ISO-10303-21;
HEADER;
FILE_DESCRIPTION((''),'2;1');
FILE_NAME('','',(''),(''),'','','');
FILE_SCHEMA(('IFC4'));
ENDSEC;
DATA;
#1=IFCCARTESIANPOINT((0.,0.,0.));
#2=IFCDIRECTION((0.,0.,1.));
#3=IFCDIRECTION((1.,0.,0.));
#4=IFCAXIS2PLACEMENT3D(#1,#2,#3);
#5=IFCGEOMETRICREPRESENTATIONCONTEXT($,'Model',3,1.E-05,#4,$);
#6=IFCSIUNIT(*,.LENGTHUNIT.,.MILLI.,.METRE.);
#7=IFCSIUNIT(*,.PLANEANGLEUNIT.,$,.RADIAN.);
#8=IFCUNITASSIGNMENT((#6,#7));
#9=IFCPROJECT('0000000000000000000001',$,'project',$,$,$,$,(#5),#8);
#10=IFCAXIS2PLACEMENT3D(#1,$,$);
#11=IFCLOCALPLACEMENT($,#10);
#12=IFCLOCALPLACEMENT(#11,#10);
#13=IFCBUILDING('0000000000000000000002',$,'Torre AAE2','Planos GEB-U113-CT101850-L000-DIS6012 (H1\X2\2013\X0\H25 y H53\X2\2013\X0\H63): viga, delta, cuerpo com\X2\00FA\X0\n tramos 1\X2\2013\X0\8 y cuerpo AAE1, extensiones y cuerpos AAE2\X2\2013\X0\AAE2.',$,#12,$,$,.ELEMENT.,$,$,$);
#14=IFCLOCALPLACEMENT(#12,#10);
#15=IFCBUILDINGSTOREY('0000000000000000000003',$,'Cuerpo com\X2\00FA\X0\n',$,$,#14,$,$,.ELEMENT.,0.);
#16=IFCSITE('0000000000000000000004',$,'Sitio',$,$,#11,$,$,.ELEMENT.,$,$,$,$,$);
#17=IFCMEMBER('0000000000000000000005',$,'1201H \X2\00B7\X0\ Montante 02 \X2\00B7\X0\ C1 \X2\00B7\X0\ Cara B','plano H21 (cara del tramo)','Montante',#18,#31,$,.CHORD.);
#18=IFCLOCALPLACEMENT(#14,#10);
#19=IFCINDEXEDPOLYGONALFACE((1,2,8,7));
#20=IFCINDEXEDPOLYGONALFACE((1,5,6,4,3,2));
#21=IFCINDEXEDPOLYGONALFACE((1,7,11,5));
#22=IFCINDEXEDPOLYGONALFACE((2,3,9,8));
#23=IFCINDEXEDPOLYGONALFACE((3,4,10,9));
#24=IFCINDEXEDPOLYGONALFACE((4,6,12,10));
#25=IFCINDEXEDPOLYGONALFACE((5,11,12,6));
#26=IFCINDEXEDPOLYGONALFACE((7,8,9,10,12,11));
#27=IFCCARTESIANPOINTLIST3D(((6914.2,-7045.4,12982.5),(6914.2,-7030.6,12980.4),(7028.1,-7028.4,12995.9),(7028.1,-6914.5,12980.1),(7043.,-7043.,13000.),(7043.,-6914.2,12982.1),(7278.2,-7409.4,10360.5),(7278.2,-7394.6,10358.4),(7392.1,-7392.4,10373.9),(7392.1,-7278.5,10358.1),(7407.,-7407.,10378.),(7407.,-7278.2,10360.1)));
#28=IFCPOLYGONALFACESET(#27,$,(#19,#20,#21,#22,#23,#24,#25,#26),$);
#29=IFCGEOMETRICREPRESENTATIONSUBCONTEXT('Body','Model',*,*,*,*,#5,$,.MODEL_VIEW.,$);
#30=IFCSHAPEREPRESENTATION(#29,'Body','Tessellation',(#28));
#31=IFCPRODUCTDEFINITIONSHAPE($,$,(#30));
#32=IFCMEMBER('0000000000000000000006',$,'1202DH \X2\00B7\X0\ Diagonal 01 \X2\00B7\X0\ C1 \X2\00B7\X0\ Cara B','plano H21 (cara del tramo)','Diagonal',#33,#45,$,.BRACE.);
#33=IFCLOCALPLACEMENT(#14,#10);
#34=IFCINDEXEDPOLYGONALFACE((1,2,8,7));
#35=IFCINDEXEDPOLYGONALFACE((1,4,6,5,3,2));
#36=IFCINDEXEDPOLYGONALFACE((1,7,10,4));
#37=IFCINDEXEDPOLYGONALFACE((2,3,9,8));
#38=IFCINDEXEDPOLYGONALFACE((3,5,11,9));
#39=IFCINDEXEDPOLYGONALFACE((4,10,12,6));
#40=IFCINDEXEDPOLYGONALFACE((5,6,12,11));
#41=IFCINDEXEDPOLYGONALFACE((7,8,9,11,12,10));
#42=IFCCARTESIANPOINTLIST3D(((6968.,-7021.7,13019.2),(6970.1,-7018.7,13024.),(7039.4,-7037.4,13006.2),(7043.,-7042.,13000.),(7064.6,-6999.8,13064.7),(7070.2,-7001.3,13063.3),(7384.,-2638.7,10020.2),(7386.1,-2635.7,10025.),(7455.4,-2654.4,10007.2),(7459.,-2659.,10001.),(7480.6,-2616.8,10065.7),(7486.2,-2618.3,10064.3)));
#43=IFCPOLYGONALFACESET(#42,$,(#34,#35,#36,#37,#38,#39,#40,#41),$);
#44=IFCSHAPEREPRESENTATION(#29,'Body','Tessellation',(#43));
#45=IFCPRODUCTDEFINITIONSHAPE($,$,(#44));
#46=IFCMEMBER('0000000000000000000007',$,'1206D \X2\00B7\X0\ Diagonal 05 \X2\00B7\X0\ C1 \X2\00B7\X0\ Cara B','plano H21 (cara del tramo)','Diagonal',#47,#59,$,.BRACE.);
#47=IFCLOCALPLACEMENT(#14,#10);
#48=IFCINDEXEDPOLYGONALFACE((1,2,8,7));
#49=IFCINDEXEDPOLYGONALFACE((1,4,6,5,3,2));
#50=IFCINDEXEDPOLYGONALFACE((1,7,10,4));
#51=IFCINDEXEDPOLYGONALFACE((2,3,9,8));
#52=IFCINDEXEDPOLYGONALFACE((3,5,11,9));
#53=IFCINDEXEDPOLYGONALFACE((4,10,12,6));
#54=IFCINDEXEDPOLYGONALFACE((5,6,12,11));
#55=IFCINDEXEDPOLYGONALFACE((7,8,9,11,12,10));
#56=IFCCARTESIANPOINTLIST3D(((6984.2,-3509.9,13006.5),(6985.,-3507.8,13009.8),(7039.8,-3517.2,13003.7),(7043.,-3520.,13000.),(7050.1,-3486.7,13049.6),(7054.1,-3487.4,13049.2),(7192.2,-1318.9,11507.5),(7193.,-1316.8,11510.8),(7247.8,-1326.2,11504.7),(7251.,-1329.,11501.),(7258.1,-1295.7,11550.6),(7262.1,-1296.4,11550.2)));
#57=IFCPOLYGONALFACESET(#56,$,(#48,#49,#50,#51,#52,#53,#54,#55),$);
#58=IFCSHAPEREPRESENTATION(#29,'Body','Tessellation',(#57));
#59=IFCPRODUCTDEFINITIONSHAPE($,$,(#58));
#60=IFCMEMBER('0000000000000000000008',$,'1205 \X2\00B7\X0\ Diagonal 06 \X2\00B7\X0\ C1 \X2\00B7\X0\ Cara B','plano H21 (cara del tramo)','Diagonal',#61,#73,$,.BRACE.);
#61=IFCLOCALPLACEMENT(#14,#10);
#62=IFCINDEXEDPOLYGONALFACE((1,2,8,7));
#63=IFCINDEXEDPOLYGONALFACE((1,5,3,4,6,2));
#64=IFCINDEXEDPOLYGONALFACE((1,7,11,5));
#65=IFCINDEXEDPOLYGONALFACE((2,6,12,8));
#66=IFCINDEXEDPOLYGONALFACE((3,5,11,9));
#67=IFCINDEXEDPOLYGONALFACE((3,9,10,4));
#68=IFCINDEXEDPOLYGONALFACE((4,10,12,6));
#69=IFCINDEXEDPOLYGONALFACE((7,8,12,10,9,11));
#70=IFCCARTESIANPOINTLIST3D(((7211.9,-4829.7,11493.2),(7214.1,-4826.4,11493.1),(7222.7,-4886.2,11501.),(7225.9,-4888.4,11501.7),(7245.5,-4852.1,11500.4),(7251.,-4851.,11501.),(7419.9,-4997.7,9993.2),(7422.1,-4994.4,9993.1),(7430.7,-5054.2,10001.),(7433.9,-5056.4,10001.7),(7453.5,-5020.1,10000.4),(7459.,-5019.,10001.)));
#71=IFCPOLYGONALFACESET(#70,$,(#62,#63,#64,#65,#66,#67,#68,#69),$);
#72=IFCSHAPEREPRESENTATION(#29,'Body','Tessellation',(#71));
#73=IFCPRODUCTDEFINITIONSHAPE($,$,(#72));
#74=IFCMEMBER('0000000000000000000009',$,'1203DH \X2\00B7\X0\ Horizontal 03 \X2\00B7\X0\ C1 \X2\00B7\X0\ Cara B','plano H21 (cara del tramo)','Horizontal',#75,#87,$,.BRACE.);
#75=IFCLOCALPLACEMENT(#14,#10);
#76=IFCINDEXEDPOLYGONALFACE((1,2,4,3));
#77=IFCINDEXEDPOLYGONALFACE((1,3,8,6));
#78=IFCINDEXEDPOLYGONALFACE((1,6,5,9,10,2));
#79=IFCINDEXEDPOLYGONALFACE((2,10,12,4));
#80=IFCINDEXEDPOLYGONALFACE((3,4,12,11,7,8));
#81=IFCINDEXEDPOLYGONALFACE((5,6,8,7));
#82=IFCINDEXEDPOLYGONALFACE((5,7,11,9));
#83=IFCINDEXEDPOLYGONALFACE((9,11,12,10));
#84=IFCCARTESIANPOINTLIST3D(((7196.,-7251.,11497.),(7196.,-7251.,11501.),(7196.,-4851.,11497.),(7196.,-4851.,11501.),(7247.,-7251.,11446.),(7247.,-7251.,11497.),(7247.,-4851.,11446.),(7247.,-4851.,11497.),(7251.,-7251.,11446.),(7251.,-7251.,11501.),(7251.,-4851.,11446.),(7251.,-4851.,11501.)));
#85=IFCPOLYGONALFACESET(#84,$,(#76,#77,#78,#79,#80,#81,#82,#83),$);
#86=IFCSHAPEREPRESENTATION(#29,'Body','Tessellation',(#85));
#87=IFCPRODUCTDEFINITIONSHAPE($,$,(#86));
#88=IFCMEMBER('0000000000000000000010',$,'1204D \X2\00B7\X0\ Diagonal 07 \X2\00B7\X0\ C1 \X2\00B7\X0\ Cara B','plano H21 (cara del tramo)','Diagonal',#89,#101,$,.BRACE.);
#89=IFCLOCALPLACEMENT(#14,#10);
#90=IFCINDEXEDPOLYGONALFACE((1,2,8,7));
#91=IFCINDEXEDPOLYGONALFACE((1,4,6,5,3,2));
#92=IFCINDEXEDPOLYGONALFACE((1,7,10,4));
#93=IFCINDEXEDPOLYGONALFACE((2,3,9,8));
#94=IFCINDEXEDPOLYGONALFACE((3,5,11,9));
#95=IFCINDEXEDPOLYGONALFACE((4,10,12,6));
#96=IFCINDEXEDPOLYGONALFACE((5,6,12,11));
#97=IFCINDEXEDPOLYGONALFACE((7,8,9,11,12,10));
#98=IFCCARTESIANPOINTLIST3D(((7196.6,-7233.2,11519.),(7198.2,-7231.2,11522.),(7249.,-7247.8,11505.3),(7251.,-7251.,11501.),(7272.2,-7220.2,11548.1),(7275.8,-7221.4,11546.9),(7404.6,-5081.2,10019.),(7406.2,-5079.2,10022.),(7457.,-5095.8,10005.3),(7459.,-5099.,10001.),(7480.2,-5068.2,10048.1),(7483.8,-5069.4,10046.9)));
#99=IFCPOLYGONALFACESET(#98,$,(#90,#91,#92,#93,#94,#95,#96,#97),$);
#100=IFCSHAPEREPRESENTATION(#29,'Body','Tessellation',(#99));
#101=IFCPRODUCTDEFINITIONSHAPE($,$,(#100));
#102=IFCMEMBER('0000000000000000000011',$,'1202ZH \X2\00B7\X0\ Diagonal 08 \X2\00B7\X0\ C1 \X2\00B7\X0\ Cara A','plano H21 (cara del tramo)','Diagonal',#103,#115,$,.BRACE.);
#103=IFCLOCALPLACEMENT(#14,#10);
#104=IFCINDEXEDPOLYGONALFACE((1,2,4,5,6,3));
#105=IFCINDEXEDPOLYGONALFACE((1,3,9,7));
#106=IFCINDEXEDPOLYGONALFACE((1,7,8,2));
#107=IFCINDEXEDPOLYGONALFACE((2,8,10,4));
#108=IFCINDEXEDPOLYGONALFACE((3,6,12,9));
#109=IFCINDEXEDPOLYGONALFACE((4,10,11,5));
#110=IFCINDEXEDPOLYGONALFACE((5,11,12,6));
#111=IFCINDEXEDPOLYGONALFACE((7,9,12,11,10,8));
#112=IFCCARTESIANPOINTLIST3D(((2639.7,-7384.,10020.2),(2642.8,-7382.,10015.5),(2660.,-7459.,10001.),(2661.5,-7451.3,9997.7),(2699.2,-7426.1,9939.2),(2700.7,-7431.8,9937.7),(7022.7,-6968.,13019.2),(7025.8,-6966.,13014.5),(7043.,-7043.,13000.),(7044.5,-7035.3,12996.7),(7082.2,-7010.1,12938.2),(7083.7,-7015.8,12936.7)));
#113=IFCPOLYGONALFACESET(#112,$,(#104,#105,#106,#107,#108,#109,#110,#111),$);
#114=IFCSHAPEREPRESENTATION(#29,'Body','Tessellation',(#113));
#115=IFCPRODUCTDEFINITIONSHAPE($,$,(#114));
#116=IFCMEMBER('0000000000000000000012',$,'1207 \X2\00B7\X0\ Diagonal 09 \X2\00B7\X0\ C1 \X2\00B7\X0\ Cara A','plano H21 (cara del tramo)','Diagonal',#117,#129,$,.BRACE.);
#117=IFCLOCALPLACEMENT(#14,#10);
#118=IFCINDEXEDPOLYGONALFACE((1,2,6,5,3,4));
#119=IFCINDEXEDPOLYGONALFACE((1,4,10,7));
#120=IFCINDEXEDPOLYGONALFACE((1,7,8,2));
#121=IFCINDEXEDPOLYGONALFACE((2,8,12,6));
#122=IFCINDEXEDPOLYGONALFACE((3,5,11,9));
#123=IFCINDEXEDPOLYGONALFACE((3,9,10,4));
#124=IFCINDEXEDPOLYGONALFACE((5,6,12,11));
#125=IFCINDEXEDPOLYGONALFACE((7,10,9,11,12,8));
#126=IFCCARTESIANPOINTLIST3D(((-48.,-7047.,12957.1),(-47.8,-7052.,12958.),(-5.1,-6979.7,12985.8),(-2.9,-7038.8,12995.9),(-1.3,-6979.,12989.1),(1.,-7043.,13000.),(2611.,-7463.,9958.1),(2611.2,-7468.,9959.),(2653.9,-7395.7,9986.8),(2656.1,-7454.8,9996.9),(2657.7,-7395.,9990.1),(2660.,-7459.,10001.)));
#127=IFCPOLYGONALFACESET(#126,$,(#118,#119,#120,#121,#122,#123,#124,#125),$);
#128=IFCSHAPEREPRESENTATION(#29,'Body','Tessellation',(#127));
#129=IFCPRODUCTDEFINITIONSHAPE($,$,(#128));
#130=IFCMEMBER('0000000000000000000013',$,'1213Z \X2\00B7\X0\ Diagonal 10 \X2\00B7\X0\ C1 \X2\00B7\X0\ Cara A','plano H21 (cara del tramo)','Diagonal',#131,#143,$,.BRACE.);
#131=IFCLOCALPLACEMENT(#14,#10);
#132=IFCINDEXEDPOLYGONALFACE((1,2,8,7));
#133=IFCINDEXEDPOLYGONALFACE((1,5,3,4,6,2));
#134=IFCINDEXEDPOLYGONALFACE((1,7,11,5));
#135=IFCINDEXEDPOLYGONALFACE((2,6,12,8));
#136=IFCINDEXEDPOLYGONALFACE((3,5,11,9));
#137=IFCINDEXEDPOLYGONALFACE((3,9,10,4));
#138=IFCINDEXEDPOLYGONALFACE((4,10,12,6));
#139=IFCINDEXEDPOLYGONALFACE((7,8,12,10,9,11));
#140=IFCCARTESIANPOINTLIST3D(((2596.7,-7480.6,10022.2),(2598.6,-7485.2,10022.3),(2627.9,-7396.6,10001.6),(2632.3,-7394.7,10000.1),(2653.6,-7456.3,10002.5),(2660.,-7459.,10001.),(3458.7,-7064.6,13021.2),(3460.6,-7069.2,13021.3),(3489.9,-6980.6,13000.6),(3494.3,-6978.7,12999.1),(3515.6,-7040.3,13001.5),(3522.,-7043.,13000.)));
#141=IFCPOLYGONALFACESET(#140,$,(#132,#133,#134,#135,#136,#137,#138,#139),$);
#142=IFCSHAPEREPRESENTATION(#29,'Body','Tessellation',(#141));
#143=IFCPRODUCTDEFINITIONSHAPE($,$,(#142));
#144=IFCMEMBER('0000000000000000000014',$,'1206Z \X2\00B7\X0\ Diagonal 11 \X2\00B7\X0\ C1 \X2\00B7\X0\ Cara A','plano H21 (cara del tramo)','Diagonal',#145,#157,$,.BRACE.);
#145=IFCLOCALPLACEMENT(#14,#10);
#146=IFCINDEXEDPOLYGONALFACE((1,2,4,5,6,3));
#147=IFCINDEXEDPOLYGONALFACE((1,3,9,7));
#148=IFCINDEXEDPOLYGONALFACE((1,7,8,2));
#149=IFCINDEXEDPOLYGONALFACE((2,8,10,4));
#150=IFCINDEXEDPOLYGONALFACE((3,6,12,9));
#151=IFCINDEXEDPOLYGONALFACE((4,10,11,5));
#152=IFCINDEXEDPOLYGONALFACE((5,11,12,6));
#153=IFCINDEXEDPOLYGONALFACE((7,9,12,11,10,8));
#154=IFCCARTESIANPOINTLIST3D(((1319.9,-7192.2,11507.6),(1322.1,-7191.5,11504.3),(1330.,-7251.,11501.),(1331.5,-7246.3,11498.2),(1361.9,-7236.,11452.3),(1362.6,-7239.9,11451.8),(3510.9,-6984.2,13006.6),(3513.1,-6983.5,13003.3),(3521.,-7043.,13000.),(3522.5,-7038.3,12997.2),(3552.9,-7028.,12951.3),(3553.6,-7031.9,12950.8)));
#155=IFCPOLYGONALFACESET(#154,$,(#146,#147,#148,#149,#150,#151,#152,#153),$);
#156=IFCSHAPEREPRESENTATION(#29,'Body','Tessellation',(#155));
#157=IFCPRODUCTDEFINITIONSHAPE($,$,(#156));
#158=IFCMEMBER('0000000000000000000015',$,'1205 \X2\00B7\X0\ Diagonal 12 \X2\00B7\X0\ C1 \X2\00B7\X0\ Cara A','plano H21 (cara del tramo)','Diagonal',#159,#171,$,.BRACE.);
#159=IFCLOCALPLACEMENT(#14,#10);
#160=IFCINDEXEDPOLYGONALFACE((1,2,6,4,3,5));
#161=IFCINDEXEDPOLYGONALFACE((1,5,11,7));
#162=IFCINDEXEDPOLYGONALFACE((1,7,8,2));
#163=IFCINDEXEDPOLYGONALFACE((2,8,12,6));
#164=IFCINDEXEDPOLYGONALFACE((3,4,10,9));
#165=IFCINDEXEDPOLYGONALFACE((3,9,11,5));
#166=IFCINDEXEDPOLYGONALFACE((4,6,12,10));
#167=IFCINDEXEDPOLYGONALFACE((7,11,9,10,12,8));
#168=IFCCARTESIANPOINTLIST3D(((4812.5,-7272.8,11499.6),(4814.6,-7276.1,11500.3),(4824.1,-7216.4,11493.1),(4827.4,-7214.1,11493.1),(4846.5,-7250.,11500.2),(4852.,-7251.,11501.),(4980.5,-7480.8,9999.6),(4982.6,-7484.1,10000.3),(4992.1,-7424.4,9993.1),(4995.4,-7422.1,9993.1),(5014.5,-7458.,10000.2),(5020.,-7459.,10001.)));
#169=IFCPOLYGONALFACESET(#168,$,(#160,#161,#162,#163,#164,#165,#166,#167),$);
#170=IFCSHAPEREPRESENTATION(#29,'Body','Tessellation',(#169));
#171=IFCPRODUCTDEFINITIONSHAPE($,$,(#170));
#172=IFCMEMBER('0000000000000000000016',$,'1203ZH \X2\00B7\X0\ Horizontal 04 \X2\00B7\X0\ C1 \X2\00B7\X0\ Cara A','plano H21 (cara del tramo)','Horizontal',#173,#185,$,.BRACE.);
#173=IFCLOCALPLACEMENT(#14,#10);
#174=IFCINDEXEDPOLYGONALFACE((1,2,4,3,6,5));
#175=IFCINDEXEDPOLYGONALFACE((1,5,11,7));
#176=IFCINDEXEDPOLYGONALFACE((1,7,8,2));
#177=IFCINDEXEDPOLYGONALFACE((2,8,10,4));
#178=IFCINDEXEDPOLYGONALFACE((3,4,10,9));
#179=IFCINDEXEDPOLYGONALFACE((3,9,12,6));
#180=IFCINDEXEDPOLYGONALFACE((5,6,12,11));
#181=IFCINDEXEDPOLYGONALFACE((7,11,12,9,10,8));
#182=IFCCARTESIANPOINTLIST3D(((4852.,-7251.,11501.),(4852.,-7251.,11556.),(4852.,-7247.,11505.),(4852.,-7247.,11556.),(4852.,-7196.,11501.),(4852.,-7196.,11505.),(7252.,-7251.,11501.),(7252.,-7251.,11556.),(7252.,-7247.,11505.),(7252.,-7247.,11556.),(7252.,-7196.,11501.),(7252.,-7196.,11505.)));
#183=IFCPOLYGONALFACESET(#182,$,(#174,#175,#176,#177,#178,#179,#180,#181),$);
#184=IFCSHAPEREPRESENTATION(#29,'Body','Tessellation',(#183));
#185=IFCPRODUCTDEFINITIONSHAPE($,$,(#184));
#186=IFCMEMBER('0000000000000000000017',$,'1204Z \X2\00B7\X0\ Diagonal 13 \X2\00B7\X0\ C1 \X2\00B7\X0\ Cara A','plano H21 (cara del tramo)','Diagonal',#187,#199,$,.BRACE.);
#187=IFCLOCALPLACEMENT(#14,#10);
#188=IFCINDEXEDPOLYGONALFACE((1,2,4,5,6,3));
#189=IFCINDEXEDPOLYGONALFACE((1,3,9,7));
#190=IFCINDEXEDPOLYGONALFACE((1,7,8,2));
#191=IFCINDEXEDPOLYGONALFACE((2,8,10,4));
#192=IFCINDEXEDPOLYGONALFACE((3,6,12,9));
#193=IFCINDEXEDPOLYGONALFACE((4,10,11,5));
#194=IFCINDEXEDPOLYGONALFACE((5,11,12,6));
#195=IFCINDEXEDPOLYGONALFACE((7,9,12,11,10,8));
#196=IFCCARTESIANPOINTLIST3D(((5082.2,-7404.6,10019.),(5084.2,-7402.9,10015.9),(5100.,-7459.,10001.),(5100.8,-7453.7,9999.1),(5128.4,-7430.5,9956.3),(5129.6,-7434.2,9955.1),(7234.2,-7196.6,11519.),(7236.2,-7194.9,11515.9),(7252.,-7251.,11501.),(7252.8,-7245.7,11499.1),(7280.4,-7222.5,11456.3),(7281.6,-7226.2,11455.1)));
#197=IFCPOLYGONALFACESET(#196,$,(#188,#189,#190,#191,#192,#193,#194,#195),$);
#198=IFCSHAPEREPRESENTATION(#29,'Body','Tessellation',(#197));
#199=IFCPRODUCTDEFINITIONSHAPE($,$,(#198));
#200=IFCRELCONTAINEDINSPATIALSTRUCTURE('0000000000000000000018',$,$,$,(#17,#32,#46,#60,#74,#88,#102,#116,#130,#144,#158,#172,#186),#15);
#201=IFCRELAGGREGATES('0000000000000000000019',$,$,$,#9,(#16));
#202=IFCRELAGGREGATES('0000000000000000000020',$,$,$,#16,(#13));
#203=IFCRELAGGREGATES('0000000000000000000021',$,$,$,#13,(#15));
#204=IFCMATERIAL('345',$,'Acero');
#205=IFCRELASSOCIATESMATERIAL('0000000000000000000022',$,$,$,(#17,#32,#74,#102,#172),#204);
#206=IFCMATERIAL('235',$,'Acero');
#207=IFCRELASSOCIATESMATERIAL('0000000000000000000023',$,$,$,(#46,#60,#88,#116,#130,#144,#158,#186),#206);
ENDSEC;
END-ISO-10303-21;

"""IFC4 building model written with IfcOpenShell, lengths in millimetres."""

from ifc_helpers import new_model, si_unit, frame, frame_2d, origin, origin_with_axes, place, context, subcontext, project, spatial, l_section, extrude, material, element, save


model = new_model("IFC4")

# Units and contexts
model_context = context("Model", 3, precision=1e-05, world=origin_with_axes())
body_context = subcontext(model_context, "Body", "Model", "MODEL_VIEW")
ifc_project = project(units=[si_unit("LENGTHUNIT", "METRE", prefix="MILLI"), si_unit("PLANEANGLEUNIT", "RADIAN")], contexts=[model_context])

# Site, building, storey
site_placement = place(None, origin())
site = spatial("IfcSite", under=ifc_project, at=site_placement, Name="Sitio", CompositionType="ELEMENT")
building_placement = place(site_placement, origin())
building = spatial("IfcBuilding", under=site, at=building_placement, Name="Torre AAE2", Description="Planos GEB-U113-CT101850-L000-DIS6012 (H1–H25 y H53–H63): viga, delta, cuerpo común tramos 1–8 y cuerpo AAE1, extensiones y cuerpos AAE2–AAE2.", CompositionType="ELEMENT")
storey_placement = place(building_placement, origin())
storey = spatial("IfcBuildingStorey", under=building, at=storey_placement, Name="Cuerpo común", CompositionType="ELEMENT", Elevation=0.0)

# Members
ifc_material_1 = material(Name="345", Category="Acero")
ifc_material_2 = material(Name="235", Category="Acero")
member_1_placement = place(storey_placement, frame((7043.0, -7043.0, 13000.0), z_axis=(0.136225, -0.136225, -0.981267), x_axis=(-0.990678, -0.018732, -0.134931)))
element("IfcMember", 1, at=member_1_placement, inside=storey, material=ifc_material_1, Name="1201H · Montante 02 · C1 · Cara B", Description="plano H21 (cara del tramo)", ObjectType="Montante", PredefinedType="CHORD", context=body_context, shape_type="SweptSolid", body=[
    extrude(l_section(Depth=130.0, Width=130.0, Thickness=15.0, at=frame_2d((65.0, 65.0))), None, (0.0, 0.0, 1.0), 2672.1),
])
member_2_placement = place(storey_placement, frame((7043.0, -7042.0, 13000.0), z_axis=(0.078092, 0.822778, -0.562973), x_axis=(-0.937055, 0.253354, 0.240292)))
element("IfcMember", 2, at=member_2_placement, inside=storey, material=ifc_material_1, Name="1202DH · Diagonal 01 · C1 · Cara B", Description="plano H21 (cara del tramo)", ObjectType="Diagonal", PredefinedType="BRACE", context=body_context, shape_type="SweptSolid", body=[
    extrude(l_section(Depth=80.0, Width=80.0, Thickness=6.0, at=frame_2d((40.0, 40.0))), None, (0.0, 0.0, 1.0), 5327.1),
])
member_3_placement = place(storey_placement, frame((7043.0, -3520.0, 13000.0), z_axis=(0.078112, 0.822804, -0.562932), x_axis=(-0.979778, 0.167693, 0.109153)))
element("IfcMember", 3, at=member_3_placement, inside=storey, material=ifc_material_2, Name="1206D · Diagonal 05 · C1 · Cara B", Description="plano H21 (cara del tramo)", ObjectType="Diagonal", PredefinedType="BRACE", context=body_context, shape_type="SweptSolid", body=[
    extrude(l_section(Depth=60.0, Width=60.0, Thickness=4.0, at=frame_2d((30.0, 30.0))), None, (0.0, 0.0, 1.0), 2662.8),
])
member_4_placement = place(storey_placement, frame((7459.0, -5019.0, 10001.0), z_axis=(-0.136515, 0.110262, 0.984483), x_axis=(-0.819145, 0.54631, -0.174775)))
element("IfcMember", 4, at=member_4_placement, inside=storey, material=ifc_material_2, Name="1205 · Diagonal 06 · C1 · Cara B", Description="plano H21 (cara del tramo)", ObjectType="Diagonal", PredefinedType="BRACE", context=body_context, shape_type="SweptSolid", body=[
    extrude(l_section(Depth=45.0, Width=45.0, Thickness=4.0, at=frame_2d((22.5, 22.5))), None, (0.0, 0.0, 1.0), 1523.6),
])
member_5_placement = place(storey_placement, frame((7251.0, -4851.0, 11501.0), z_axis=(0.0, -1.0, 0.0), x_axis=(-1.0, 0.0, 0.0)))
element("IfcMember", 5, at=member_5_placement, inside=storey, material=ifc_material_1, Name="1203DH · Horizontal 03 · C1 · Cara B", Description="plano H21 (cara del tramo)", ObjectType="Horizontal", PredefinedType="BRACE", context=body_context, shape_type="SweptSolid", body=[
    extrude(l_section(Depth=55.0, Width=55.0, Thickness=4.0, at=frame_2d((27.5, 27.5))), None, (0.0, 0.0, 1.0), 2400.0),
])
member_6_placement = place(storey_placement, frame((7251.0, -7251.0, 11501.0), z_axis=(0.079045, 0.81781, -0.570035), x_axis=(-0.906797, 0.296517, 0.29966)))
element("IfcMember", 6, at=member_6_placement, inside=storey, material=ifc_material_2, Name="1204D · Diagonal 07 · C1 · Cara B", Description="plano H21 (cara del tramo)", ObjectType="Diagonal", PredefinedType="BRACE", context=body_context, shape_type="SweptSolid", body=[
    extrude(l_section(Depth=60.0, Width=60.0, Thickness=4.0, at=frame_2d((30.0, 30.0))), None, (0.0, 0.0, 1.0), 2631.4),
])
member_7_placement = place(storey_placement, frame((7043.0, -7043.0, 13000.0), z_axis=(-0.822778, -0.078092, -0.562973), x_axis=(-0.253386, 0.937033, 0.240342)))
element("IfcMember", 7, at=member_7_placement, inside=storey, material=ifc_material_1, Name="1202ZH · Diagonal 08 · C1 · Cara A", Description="plano H21 (cara del tramo)", ObjectType="Diagonal", PredefinedType="BRACE", context=body_context, shape_type="SweptSolid", body=[
    extrude(l_section(Depth=80.0, Width=80.0, Thickness=6.0, at=frame_2d((40.0, 40.0))), None, (0.0, 0.0, 1.0), 5327.1),
])
member_8_placement = place(storey_placement, frame((2660.0, -7459.0, 10001.0), z_axis=(-0.659874, 0.103237, 0.74425), x_axis=(-0.035769, 0.985077, -0.168357)))
element("IfcMember", 8, at=member_8_placement, inside=storey, material=ifc_material_2, Name="1207 · Diagonal 09 · C1 · Cara A", Description="plano H21 (cara del tramo)", ObjectType="Diagonal", PredefinedType="BRACE", context=body_context, shape_type="SweptSolid", body=[
    extrude(l_section(Depth=65.0, Width=65.0, Thickness=5.0, at=frame_2d((32.5, 32.5))), None, (0.0, 0.0, 1.0), 4029.6),
])
member_9_placement = place(storey_placement, frame((2660.0, -7459.0, 10001.0), z_axis=(0.273822, 0.132146, 0.952659), x_axis=(-0.396066, 0.918122, -0.013514)))
element("IfcMember", 9, at=member_9_placement, inside=storey, material=ifc_material_2, Name="1213Z · Diagonal 10 · C1 · Cara A", Description="plano H21 (cara del tramo)", ObjectType="Diagonal", PredefinedType="BRACE", context=body_context, shape_type="SweptSolid", body=[
    extrude(l_section(Depth=70.0, Width=70.0, Thickness=5.0, at=frame_2d((35.0, 35.0))), None, (0.0, 0.0, 1.0), 3148.0),
])
member_10_placement = place(storey_placement, frame((3521.0, -7043.0, 13000.0), z_axis=(-0.822804, -0.078112, -0.562932), x_axis=(-0.167732, 0.979764, 0.109213)))
element("IfcMember", 10, at=member_10_placement, inside=storey, material=ifc_material_2, Name="1206Z · Diagonal 11 · C1 · Cara A", Description="plano H21 (cara del tramo)", ObjectType="Diagonal", PredefinedType="BRACE", context=body_context, shape_type="SweptSolid", body=[
    extrude(l_section(Depth=60.0, Width=60.0, Thickness=4.0, at=frame_2d((30.0, 30.0))), None, (0.0, 0.0, 1.0), 2662.8),
])
member_11_placement = place(storey_placement, frame((5020.0, -7459.0, 10001.0), z_axis=(-0.110262, 0.136515, 0.984483), x_axis=(-0.546389, 0.819092, -0.174776)))
element("IfcMember", 11, at=member_11_placement, inside=storey, material=ifc_material_2, Name="1205 · Diagonal 12 · C1 · Cara A", Description="plano H21 (cara del tramo)", ObjectType="Diagonal", PredefinedType="BRACE", context=body_context, shape_type="SweptSolid", body=[
    extrude(l_section(Depth=45.0, Width=45.0, Thickness=4.0, at=frame_2d((22.5, 22.5))), None, (0.0, 0.0, 1.0), 1523.6),
])
member_12_placement = place(storey_placement, frame((4852.0, -7251.0, 11501.0), z_axis=(1.0, 0.0, 0.0), x_axis=(0.0, 1.0, 0.0)))
element("IfcMember", 12, at=member_12_placement, inside=storey, material=ifc_material_1, Name="1203ZH · Horizontal 04 · C1 · Cara A", Description="plano H21 (cara del tramo)", ObjectType="Horizontal", PredefinedType="BRACE", context=body_context, shape_type="SweptSolid", body=[
    extrude(l_section(Depth=55.0, Width=55.0, Thickness=4.0, at=frame_2d((27.5, 27.5))), None, (0.0, 0.0, 1.0), 2400.0),
])
member_13_placement = place(storey_placement, frame((7252.0, -7251.0, 11501.0), z_axis=(-0.81781, -0.079045, -0.570035), x_axis=(-0.296545, 0.906773, 0.299704)))
element("IfcMember", 13, at=member_13_placement, inside=storey, material=ifc_material_2, Name="1204Z · Diagonal 13 · C1 · Cara A", Description="plano H21 (cara del tramo)", ObjectType="Diagonal", PredefinedType="BRACE", context=body_context, shape_type="SweptSolid", body=[
    extrude(l_section(Depth=60.0, Width=60.0, Thickness=4.0, at=frame_2d((30.0, 30.0))), None, (0.0, 0.0, 1.0), 2631.4),
])

save(model, "model.ifc")
